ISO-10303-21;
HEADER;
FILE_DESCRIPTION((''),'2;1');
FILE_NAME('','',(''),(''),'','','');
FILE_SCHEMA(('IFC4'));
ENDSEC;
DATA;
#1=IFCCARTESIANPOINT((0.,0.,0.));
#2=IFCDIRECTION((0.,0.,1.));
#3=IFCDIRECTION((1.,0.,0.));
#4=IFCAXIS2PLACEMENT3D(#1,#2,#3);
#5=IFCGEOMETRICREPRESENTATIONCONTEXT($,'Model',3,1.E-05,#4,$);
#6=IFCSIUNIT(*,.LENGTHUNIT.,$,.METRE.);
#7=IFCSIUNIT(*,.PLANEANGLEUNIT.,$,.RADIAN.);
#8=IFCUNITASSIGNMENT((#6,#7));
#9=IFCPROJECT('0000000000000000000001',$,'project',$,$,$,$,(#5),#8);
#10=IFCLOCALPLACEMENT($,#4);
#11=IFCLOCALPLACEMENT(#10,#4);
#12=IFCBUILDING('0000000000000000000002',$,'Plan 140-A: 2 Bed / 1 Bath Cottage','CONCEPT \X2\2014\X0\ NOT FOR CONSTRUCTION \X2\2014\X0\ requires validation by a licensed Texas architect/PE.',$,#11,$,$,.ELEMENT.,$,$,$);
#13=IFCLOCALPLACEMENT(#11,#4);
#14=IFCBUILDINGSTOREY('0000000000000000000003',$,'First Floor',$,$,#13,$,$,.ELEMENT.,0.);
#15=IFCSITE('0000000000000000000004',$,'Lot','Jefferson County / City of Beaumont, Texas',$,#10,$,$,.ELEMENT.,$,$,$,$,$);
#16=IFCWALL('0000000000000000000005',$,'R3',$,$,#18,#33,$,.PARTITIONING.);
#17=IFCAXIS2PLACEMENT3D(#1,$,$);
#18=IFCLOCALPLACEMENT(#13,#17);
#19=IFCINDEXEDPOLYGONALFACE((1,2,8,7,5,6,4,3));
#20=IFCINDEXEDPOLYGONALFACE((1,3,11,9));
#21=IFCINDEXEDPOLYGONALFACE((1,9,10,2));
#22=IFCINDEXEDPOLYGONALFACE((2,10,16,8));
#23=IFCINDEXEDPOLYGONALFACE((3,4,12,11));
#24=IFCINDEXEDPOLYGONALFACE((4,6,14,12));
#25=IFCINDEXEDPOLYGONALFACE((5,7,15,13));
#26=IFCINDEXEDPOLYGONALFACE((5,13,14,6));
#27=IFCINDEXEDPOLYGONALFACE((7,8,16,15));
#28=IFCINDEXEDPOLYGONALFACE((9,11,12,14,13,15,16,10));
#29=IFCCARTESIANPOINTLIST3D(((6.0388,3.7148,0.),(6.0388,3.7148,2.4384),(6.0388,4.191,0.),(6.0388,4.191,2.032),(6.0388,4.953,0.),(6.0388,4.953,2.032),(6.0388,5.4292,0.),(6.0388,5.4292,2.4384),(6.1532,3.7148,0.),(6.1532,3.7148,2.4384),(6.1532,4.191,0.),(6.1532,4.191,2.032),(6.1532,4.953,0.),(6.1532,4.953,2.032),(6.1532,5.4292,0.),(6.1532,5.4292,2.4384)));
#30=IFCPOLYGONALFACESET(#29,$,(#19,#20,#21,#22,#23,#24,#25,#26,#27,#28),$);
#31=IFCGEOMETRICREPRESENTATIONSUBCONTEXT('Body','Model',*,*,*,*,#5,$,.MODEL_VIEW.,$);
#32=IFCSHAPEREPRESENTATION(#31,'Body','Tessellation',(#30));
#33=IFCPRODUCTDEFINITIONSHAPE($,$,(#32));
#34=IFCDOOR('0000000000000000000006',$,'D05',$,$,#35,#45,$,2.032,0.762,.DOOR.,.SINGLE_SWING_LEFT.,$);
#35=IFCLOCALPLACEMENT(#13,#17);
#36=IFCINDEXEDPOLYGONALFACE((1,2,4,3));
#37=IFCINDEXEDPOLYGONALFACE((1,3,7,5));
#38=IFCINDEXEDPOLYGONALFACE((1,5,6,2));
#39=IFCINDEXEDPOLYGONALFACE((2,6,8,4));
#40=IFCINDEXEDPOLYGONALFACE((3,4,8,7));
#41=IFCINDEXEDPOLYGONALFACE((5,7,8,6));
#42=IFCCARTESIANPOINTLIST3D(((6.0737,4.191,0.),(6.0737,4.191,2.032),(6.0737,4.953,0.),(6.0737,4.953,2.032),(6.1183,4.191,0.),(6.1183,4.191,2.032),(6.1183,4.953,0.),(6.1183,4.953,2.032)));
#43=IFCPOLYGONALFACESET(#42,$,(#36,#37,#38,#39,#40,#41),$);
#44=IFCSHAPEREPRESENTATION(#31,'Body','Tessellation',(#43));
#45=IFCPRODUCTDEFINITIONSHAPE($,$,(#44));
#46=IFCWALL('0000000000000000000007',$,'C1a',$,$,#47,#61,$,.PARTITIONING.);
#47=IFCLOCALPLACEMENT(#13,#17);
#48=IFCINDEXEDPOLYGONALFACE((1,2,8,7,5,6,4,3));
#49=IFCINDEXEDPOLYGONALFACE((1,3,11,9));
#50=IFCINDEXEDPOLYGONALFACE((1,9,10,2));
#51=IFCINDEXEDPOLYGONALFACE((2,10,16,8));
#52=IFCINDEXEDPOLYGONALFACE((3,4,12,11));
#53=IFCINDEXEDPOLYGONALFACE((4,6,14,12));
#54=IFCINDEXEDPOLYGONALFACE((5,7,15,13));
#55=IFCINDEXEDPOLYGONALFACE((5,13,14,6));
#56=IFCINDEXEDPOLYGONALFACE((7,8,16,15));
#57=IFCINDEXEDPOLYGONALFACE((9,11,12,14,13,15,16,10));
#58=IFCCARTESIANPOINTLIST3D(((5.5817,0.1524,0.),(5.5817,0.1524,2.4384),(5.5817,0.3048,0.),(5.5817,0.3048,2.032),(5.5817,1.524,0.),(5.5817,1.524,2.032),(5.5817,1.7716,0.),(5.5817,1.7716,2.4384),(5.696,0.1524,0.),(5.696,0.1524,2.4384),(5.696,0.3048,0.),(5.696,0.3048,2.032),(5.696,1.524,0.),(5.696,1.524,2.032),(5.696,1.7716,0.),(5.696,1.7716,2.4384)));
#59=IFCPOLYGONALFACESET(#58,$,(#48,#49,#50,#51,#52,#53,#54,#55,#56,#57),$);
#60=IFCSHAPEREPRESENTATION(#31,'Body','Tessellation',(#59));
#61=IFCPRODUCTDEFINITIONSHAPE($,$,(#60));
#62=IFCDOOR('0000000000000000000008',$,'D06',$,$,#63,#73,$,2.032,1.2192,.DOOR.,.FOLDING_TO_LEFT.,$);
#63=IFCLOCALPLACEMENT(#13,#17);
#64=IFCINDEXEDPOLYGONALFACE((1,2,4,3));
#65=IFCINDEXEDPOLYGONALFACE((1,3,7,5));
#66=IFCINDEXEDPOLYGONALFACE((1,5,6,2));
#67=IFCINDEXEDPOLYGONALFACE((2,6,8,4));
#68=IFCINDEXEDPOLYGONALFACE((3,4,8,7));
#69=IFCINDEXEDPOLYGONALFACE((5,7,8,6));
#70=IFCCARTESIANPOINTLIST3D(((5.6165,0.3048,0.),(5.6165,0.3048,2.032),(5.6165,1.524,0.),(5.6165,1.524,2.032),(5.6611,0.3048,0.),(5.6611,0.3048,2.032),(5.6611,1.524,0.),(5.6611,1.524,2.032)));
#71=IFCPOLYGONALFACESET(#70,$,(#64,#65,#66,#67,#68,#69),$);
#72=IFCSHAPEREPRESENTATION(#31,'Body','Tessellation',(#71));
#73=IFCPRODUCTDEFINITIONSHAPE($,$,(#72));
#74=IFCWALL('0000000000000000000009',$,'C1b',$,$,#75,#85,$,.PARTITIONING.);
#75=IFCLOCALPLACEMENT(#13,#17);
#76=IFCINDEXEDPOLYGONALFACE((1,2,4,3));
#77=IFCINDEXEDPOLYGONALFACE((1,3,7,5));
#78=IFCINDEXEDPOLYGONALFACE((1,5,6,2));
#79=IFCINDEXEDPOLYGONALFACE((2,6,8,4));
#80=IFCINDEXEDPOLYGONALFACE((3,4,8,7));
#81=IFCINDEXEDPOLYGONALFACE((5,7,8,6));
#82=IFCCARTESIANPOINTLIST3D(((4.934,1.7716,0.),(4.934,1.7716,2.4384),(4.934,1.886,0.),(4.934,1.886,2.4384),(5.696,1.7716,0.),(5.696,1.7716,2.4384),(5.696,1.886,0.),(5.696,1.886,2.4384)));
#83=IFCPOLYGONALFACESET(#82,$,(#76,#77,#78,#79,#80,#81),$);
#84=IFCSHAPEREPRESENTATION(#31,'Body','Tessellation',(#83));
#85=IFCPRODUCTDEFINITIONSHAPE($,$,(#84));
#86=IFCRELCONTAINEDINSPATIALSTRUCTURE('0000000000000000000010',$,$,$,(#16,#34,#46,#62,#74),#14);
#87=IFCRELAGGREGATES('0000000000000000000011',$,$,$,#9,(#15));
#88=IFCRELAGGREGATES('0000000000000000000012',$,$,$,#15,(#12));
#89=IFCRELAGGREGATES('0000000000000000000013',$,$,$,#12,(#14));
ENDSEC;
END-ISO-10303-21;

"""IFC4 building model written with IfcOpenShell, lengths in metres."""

from ifc_helpers import new_model, si_unit, frame, frame_2d, origin_with_axes, place, context, subcontext, project, spatial, rectangle, extrude, element, fill, save


model = new_model("IFC4")

# Units and contexts
model_context = context("Model", 3, precision=1e-05, world=origin_with_axes())
body_context = subcontext(model_context, "Body", "Model", "MODEL_VIEW")
ifc_project = project(units=[si_unit("LENGTHUNIT", "METRE"), si_unit("PLANEANGLEUNIT", "RADIAN")], contexts=[model_context])

# Site, building, storey
site_placement = place(None, origin_with_axes())
site = spatial("IfcSite", under=ifc_project, at=site_placement, Name="Lot", Description="Jefferson County / City of Beaumont, Texas", CompositionType="ELEMENT")
building_placement = place(site_placement, origin_with_axes())
building = spatial("IfcBuilding", under=site, at=building_placement, Name="Plan 140-A: 2 Bed / 1 Bath Cottage", Description="CONCEPT — NOT FOR CONSTRUCTION — requires validation by a licensed Texas architect/PE.", CompositionType="ELEMENT")
storey_placement = place(building_placement, origin_with_axes())
storey = spatial("IfcBuildingStorey", under=building, at=storey_placement, Name="First Floor", CompositionType="ELEMENT", Elevation=0.0)

# Walls, openings, doors
wall_1_placement = place(storey_placement, frame((6.096, 3.7147, 0.0), z_axis=(0.0, 0.0, 1.0), x_axis=(0.0, 1.0, 0.0)))
wall_1 = element("IfcWall", 1, at=wall_1_placement, inside=storey, Name="R3", PredefinedType="PARTITIONING", context=body_context, shape_type="SweptSolid", body=[
    extrude(rectangle(XDim=1.7145, YDim=0.1143, at=frame_2d((0.8573, 0.0), x_axis=(1.0, 0.0))), origin_with_axes(), (0.0, 0.0, 1.0), 2.4384),
])
opening_1_placement = place(wall_1_placement, frame((0.4763, 0.0, 0.0), z_axis=(0.0, 0.0, 1.0), x_axis=(1.0, 0.0, 0.0)))
opening_1 = element("IfcOpeningElement", 2, at=opening_1_placement, cuts=wall_1, PredefinedType="OPENING", context=body_context, shape_type="SweptSolid", body=[
    extrude(rectangle(XDim=0.762, YDim=0.1448, at=frame_2d((0.381, 0.0), x_axis=(1.0, 0.0))), origin_with_axes(), (0.0, 0.0, 1.0), 2.032),
])
door_1_placement = place(opening_1_placement, origin_with_axes())
door_1 = element("IfcDoor", 3, at=door_1_placement, inside=storey, Name="D05", OperationType="SINGLE_SWING_LEFT", OverallHeight=2.032, OverallWidth=0.762, PredefinedType="DOOR", context=body_context, shape_type="SweptSolid", body=[
    extrude(rectangle(XDim=0.762, YDim=0.0445, at=frame_2d((0.381, 0.0), x_axis=(1.0, 0.0))), origin_with_axes(), (0.0, 0.0, 1.0), 2.032),
])
fill(opening_1, door_1)
wall_2_placement = place(storey_placement, frame((5.6388, 0.1524, 0.0), z_axis=(0.0, 0.0, 1.0), x_axis=(0.0, 1.0, 0.0)))
wall_2 = element("IfcWall", 4, at=wall_2_placement, inside=storey, Name="C1a", PredefinedType="PARTITIONING", context=body_context, shape_type="SweptSolid", body=[
    extrude(rectangle(XDim=1.6193, YDim=0.1143, at=frame_2d((0.8096, 0.0), x_axis=(1.0, 0.0))), origin_with_axes(), (0.0, 0.0, 1.0), 2.4384),
])
opening_2_placement = place(wall_2_placement, frame((0.1524, 0.0, 0.0), z_axis=(0.0, 0.0, 1.0), x_axis=(1.0, 0.0, 0.0)))
opening_2 = element("IfcOpeningElement", 5, at=opening_2_placement, cuts=wall_2, PredefinedType="OPENING", context=body_context, shape_type="SweptSolid", body=[
    extrude(rectangle(XDim=1.2192, YDim=0.1448, at=frame_2d((0.6096, 0.0), x_axis=(1.0, 0.0))), origin_with_axes(), (0.0, 0.0, 1.0), 2.032),
])
door_2_placement = place(opening_2_placement, origin_with_axes())
door_2 = element("IfcDoor", 6, at=door_2_placement, inside=storey, Name="D06", OperationType="FOLDING_TO_LEFT", OverallHeight=2.032, OverallWidth=1.2192, PredefinedType="DOOR", context=body_context, shape_type="SweptSolid", body=[
    extrude(rectangle(XDim=1.2192, YDim=0.0445, at=frame_2d((0.6096, 0.0), x_axis=(1.0, 0.0))), origin_with_axes(), (0.0, 0.0, 1.0), 2.032),
])
fill(opening_2, door_2)

# Wall
wall_3_placement = place(storey_placement, frame((4.934, 1.8288, 0.0), z_axis=(0.0, 0.0, 1.0), x_axis=(1.0, 0.0, 0.0)))
element("IfcWall", 7, at=wall_3_placement, inside=storey, Name="C1b", PredefinedType="PARTITIONING", context=body_context, shape_type="SweptSolid", body=[
    extrude(rectangle(XDim=0.762, YDim=0.1143, at=frame_2d((0.381, 0.0), x_axis=(1.0, 0.0))), origin_with_axes(), (0.0, 0.0, 1.0), 2.4384),
])

save(model, "model.ifc")
